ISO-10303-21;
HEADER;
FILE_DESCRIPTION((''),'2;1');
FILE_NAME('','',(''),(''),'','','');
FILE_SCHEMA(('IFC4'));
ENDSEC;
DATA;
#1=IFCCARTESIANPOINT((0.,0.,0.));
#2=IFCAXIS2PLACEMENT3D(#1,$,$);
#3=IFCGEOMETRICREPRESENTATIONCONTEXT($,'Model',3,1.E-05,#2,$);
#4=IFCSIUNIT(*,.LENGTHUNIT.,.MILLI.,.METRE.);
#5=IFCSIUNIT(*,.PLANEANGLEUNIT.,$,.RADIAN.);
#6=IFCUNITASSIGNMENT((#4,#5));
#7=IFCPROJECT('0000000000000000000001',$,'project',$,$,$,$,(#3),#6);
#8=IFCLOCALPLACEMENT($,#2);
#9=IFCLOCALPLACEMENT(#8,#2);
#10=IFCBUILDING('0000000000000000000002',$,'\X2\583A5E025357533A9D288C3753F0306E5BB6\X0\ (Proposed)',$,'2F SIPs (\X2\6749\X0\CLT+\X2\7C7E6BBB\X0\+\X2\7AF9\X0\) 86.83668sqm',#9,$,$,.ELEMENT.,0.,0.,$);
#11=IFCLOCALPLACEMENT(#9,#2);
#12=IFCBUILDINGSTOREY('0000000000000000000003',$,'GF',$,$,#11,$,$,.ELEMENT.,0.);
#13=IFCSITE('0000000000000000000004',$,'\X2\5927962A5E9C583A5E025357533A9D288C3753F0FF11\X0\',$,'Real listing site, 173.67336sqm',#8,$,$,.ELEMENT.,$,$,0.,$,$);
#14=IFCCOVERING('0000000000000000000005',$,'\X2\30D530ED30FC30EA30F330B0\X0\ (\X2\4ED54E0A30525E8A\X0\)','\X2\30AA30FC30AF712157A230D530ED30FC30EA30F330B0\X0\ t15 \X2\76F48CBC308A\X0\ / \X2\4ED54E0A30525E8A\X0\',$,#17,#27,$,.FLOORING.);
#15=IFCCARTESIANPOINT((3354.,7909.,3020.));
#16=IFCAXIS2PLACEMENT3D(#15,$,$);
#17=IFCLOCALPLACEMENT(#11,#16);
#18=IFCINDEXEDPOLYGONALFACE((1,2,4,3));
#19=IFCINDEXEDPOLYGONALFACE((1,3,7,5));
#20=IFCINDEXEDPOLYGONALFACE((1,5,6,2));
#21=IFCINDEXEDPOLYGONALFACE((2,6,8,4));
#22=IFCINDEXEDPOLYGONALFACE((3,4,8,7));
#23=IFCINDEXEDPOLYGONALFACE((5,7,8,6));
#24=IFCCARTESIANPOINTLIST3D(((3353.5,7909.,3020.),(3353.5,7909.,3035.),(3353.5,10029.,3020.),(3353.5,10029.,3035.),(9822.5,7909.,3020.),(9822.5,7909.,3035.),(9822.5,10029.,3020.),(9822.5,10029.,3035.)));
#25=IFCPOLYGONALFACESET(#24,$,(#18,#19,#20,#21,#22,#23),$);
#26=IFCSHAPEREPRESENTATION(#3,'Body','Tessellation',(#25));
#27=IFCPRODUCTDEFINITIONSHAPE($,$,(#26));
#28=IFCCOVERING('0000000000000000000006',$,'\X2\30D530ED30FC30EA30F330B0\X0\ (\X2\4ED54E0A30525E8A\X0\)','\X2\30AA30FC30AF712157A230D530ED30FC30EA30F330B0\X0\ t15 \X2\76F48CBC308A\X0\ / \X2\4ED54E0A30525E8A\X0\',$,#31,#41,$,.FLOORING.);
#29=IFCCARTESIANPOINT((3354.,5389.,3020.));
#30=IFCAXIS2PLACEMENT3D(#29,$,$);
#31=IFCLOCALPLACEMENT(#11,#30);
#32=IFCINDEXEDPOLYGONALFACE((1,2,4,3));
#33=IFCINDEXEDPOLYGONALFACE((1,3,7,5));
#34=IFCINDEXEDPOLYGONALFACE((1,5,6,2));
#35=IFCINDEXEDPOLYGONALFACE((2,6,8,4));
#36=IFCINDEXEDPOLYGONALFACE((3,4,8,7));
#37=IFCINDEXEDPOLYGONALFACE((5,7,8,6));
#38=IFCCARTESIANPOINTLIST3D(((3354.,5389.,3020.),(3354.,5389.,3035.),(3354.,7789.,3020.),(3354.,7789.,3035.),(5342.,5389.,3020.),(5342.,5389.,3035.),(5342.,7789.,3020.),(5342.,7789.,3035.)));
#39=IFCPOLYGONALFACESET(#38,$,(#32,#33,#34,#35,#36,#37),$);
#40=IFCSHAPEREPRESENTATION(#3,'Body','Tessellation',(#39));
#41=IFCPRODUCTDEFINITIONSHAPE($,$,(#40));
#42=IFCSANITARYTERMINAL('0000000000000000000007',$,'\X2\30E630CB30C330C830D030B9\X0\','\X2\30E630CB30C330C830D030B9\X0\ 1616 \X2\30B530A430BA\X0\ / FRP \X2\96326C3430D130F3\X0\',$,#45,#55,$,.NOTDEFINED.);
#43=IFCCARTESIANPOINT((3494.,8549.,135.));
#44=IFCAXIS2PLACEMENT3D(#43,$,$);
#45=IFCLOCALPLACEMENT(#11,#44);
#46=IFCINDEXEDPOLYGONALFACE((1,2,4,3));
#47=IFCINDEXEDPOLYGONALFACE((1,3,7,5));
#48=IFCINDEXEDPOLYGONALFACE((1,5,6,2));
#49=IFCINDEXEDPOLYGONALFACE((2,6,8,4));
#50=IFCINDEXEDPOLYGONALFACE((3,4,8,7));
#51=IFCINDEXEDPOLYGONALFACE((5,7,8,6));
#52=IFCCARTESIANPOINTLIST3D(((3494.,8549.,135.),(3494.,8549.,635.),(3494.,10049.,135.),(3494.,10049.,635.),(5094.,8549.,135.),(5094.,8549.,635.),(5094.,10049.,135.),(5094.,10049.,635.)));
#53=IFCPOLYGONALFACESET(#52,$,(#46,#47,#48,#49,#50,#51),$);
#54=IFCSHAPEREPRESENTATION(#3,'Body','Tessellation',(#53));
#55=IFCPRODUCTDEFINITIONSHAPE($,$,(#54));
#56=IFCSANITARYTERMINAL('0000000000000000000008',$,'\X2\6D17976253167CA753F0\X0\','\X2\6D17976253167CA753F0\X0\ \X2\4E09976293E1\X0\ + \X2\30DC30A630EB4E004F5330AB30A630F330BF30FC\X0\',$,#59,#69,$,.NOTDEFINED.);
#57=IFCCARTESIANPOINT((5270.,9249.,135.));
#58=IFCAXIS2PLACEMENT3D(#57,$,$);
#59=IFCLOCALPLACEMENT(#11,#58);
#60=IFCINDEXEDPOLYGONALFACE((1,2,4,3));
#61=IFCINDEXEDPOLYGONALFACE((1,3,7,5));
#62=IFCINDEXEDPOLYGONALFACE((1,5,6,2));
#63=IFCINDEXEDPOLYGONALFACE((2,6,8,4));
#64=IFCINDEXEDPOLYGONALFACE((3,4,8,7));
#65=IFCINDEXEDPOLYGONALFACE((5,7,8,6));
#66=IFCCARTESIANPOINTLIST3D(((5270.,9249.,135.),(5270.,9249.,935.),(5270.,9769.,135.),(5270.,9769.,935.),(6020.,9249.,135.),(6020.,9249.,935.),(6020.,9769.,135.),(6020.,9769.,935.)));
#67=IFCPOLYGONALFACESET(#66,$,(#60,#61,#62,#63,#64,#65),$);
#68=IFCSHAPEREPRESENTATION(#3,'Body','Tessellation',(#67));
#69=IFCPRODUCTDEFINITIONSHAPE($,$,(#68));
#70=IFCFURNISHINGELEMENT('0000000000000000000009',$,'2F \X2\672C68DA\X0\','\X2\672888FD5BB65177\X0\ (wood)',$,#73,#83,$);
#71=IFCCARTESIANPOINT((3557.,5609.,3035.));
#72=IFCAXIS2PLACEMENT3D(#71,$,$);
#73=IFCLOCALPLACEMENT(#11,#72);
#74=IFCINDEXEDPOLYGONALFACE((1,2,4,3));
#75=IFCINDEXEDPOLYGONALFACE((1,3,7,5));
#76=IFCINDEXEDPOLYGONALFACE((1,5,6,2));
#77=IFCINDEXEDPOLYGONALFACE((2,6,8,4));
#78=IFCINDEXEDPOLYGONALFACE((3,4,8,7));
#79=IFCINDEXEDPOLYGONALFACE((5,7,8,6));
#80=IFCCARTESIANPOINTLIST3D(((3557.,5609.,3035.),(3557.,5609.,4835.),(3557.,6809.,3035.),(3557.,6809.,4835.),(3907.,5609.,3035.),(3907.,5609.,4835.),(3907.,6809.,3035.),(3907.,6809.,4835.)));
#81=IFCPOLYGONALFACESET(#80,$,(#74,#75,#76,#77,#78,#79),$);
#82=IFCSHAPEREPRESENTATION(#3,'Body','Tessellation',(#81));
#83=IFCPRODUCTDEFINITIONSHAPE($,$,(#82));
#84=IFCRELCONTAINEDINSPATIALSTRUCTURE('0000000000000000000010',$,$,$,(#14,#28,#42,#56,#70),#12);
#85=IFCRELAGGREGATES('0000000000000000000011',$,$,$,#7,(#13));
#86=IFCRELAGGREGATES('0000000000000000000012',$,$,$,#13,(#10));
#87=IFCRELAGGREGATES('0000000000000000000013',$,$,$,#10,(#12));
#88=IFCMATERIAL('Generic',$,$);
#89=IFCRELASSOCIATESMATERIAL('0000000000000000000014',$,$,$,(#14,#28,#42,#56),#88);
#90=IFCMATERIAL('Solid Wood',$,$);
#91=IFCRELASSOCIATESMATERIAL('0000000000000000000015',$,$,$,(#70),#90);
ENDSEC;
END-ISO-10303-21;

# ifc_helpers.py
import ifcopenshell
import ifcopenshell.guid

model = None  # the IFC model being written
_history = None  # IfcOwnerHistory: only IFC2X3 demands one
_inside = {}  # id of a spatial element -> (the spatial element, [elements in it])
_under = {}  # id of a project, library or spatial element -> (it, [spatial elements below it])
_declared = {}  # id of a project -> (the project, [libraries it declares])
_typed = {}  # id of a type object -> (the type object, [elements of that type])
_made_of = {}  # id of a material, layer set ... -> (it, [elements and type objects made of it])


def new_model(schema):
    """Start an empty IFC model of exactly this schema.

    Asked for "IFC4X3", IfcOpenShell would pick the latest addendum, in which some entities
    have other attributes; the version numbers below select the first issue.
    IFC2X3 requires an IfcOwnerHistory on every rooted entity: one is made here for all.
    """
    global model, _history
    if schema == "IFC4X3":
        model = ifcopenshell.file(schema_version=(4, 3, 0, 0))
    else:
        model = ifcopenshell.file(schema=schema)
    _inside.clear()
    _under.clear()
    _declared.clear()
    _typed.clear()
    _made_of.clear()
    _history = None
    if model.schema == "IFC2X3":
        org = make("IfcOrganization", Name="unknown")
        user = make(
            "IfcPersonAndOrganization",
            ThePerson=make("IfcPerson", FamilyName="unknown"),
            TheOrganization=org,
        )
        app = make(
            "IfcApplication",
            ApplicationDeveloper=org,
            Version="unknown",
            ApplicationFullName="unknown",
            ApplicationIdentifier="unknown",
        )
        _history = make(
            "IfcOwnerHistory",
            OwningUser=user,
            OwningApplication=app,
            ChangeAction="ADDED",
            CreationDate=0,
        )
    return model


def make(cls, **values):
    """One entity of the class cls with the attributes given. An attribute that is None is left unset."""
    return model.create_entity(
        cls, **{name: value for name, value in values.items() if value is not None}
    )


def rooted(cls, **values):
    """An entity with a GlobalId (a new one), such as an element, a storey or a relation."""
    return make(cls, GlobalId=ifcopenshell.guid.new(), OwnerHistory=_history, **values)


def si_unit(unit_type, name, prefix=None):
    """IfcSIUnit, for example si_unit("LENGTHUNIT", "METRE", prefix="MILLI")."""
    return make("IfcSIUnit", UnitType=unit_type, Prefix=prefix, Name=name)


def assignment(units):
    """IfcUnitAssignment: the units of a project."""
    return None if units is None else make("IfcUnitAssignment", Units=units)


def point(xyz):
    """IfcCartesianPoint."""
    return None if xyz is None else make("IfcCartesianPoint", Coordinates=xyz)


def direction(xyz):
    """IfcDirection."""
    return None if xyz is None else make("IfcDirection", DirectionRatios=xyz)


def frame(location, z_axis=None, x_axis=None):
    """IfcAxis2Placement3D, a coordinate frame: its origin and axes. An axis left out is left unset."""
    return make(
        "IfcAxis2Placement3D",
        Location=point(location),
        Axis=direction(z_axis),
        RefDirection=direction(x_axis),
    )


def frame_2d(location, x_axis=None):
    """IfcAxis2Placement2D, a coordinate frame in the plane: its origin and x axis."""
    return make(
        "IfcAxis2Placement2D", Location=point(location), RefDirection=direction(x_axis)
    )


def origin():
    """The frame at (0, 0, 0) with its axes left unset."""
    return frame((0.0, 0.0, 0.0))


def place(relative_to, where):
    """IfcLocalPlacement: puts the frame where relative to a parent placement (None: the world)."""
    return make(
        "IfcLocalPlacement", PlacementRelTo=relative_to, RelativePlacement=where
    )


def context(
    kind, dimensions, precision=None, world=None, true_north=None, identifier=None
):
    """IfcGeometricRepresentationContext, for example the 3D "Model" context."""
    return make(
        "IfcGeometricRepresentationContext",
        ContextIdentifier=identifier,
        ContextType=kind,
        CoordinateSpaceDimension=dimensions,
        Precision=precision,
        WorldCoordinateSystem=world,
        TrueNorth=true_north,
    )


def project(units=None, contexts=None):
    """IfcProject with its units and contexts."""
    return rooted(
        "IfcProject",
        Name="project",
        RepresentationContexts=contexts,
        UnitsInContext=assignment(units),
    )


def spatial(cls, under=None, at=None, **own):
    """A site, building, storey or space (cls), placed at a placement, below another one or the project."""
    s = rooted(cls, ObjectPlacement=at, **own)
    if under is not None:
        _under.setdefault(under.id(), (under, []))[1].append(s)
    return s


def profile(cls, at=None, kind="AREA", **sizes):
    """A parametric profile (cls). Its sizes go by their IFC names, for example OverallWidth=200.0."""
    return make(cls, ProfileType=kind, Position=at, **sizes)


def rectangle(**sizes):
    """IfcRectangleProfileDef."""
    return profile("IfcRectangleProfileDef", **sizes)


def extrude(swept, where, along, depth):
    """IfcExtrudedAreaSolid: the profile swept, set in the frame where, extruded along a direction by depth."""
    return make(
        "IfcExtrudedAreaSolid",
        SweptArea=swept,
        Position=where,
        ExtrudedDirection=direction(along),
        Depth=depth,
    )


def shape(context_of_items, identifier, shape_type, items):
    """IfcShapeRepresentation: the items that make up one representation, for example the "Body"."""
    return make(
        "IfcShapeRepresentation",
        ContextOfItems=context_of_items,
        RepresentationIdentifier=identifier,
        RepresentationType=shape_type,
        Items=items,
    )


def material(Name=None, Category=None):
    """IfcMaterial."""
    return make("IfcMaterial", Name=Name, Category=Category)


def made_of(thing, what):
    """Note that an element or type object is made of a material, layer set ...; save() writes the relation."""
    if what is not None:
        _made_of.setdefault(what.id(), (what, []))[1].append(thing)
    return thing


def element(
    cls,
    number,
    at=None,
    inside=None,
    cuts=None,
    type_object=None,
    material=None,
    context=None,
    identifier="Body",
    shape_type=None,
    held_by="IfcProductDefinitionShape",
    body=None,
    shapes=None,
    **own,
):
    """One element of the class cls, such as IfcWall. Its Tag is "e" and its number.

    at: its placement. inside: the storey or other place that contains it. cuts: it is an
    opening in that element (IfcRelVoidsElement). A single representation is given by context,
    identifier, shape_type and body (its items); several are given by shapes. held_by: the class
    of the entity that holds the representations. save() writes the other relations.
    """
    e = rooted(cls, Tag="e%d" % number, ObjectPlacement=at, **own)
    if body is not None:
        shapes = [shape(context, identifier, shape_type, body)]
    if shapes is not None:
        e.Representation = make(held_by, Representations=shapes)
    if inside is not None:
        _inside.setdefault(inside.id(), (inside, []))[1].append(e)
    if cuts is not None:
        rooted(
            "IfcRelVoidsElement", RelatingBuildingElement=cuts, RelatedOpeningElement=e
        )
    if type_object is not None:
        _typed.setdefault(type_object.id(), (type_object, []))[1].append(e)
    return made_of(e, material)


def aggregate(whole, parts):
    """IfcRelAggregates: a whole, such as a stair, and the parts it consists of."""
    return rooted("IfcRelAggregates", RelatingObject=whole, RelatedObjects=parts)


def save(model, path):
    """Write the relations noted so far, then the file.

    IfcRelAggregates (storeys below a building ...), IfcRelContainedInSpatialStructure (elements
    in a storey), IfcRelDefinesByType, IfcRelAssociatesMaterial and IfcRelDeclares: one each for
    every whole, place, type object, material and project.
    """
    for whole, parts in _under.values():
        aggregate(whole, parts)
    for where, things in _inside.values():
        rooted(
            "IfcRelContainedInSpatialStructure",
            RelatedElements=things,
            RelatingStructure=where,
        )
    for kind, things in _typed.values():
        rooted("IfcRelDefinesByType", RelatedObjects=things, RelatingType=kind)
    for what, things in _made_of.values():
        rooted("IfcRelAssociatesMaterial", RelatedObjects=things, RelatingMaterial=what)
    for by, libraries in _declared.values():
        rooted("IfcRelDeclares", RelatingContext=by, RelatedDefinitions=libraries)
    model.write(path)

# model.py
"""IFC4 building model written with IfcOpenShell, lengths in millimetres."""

from ifc_helpers import new_model, si_unit, frame, frame_2d, origin, place, context, project, spatial, rectangle, extrude, material, element, save


model = new_model("IFC4")

# Units and contexts
model_context = context("Model", 3, precision=1e-05, world=origin())
ifc_project = project(units=[si_unit("LENGTHUNIT", "METRE", prefix="MILLI"), si_unit("PLANEANGLEUNIT", "RADIAN")], contexts=[model_context])

# Site, building, storey
site_placement = place(None, origin())
site = spatial("IfcSite", under=ifc_project, at=site_placement, Name="大阪府堺市南区鴨谷台１", ObjectType="Real listing site, 173.67336sqm", CompositionType="ELEMENT", RefElevation=0.0)
building_placement = place(site_placement, origin())
building = spatial("IfcBuilding", under=site, at=building_placement, Name="堺市南区鴨谷台の家 (Proposed)", ObjectType="2F SIPs (杉CLT+籾殻+竹) 86.83668sqm", CompositionType="ELEMENT", ElevationOfRefHeight=0.0, ElevationOfTerrain=0.0)
storey_placement = place(building_placement, origin())
storey = spatial("IfcBuildingStorey", under=building, at=storey_placement, Name="GF", CompositionType="ELEMENT", Elevation=0.0)

# Shared definitions
ifc_material_1 = material(Name="Solid Wood")

# Coverings
ifc_material_2 = material(Name="Generic")
covering_1_placement = place(storey_placement, frame((3354.0, 7909.0, 3020.0)))
element("IfcCovering", 1, at=covering_1_placement, inside=storey, material=ifc_material_2, Name="フローリング (仕上げ床)", Description="オーク無垢フローリング t15 直貼り / 仕上げ床", PredefinedType="FLOORING", context=model_context, shape_type="SweptSolid", body=[
    extrude(rectangle(XDim=6469.0, YDim=2120.0, at=frame_2d((3234.0, 1060.0))), frame((3354.0, 7909.0, 3020.0)), (0.0, 0.0, 1.0), 15.0),
])
covering_2_placement = place(storey_placement, frame((3354.0, 5389.0, 3020.0)))
element("IfcCovering", 2, at=covering_2_placement, inside=storey, material=ifc_material_2, Name="フローリング (仕上げ床)", Description="オーク無垢フローリング t15 直貼り / 仕上げ床", PredefinedType="FLOORING", context=model_context, shape_type="SweptSolid", body=[
    extrude(rectangle(XDim=1988.0, YDim=2400.0, at=frame_2d((994.0, 1200.0))), frame((3354.0, 5389.0, 3020.0)), (0.0, 0.0, 1.0), 15.0),
])

# Sanitary terminals
sanitary_terminal_1_placement = place(storey_placement, frame((3494.0, 8549.0, 135.0)))
element("IfcSanitaryTerminal", 3, at=sanitary_terminal_1_placement, inside=storey, material=ifc_material_2, Name="ユニットバス", Description="ユニットバス 1616 サイズ / FRP 防水パン", PredefinedType="NOTDEFINED", context=model_context, shape_type="SweptSolid", body=[
    extrude(rectangle(XDim=1600.0, YDim=1500.0, at=frame_2d((800.0, 750.0))), frame((3494.0, 8549.0, 135.0)), (0.0, 0.0, 1.0), 500.0),
])
sanitary_terminal_2_placement = place(storey_placement, frame((5270.0, 9249.0, 135.0)))
element("IfcSanitaryTerminal", 4, at=sanitary_terminal_2_placement, inside=storey, material=ifc_material_2, Name="洗面化粧台", Description="洗面化粧台 三面鏡 + ボウル一体カウンター", PredefinedType="NOTDEFINED", context=model_context, shape_type="SweptSolid", body=[
    extrude(rectangle(XDim=750.0, YDim=520.0, at=frame_2d((375.0, 260.0))), frame((5270.0, 9249.0, 135.0)), (0.0, 0.0, 1.0), 800.0),
])

# Furnishing element
furnishing_placement = place(storey_placement, frame((3557.0, 5609.0, 3035.0)))
element("IfcFurnishingElement", 5, at=furnishing_placement, inside=storey, material=ifc_material_1, Name="2F 本棚", Description="木製家具 (wood)", context=model_context, shape_type="SweptSolid", body=[
    extrude(rectangle(XDim=350.0, YDim=1200.0, at=frame_2d((175.0, 600.0))), frame((3557.0, 5609.0, 3035.0)), (0.0, 0.0, 1.0), 1800.0),
])

save(model, "model.ifc")
